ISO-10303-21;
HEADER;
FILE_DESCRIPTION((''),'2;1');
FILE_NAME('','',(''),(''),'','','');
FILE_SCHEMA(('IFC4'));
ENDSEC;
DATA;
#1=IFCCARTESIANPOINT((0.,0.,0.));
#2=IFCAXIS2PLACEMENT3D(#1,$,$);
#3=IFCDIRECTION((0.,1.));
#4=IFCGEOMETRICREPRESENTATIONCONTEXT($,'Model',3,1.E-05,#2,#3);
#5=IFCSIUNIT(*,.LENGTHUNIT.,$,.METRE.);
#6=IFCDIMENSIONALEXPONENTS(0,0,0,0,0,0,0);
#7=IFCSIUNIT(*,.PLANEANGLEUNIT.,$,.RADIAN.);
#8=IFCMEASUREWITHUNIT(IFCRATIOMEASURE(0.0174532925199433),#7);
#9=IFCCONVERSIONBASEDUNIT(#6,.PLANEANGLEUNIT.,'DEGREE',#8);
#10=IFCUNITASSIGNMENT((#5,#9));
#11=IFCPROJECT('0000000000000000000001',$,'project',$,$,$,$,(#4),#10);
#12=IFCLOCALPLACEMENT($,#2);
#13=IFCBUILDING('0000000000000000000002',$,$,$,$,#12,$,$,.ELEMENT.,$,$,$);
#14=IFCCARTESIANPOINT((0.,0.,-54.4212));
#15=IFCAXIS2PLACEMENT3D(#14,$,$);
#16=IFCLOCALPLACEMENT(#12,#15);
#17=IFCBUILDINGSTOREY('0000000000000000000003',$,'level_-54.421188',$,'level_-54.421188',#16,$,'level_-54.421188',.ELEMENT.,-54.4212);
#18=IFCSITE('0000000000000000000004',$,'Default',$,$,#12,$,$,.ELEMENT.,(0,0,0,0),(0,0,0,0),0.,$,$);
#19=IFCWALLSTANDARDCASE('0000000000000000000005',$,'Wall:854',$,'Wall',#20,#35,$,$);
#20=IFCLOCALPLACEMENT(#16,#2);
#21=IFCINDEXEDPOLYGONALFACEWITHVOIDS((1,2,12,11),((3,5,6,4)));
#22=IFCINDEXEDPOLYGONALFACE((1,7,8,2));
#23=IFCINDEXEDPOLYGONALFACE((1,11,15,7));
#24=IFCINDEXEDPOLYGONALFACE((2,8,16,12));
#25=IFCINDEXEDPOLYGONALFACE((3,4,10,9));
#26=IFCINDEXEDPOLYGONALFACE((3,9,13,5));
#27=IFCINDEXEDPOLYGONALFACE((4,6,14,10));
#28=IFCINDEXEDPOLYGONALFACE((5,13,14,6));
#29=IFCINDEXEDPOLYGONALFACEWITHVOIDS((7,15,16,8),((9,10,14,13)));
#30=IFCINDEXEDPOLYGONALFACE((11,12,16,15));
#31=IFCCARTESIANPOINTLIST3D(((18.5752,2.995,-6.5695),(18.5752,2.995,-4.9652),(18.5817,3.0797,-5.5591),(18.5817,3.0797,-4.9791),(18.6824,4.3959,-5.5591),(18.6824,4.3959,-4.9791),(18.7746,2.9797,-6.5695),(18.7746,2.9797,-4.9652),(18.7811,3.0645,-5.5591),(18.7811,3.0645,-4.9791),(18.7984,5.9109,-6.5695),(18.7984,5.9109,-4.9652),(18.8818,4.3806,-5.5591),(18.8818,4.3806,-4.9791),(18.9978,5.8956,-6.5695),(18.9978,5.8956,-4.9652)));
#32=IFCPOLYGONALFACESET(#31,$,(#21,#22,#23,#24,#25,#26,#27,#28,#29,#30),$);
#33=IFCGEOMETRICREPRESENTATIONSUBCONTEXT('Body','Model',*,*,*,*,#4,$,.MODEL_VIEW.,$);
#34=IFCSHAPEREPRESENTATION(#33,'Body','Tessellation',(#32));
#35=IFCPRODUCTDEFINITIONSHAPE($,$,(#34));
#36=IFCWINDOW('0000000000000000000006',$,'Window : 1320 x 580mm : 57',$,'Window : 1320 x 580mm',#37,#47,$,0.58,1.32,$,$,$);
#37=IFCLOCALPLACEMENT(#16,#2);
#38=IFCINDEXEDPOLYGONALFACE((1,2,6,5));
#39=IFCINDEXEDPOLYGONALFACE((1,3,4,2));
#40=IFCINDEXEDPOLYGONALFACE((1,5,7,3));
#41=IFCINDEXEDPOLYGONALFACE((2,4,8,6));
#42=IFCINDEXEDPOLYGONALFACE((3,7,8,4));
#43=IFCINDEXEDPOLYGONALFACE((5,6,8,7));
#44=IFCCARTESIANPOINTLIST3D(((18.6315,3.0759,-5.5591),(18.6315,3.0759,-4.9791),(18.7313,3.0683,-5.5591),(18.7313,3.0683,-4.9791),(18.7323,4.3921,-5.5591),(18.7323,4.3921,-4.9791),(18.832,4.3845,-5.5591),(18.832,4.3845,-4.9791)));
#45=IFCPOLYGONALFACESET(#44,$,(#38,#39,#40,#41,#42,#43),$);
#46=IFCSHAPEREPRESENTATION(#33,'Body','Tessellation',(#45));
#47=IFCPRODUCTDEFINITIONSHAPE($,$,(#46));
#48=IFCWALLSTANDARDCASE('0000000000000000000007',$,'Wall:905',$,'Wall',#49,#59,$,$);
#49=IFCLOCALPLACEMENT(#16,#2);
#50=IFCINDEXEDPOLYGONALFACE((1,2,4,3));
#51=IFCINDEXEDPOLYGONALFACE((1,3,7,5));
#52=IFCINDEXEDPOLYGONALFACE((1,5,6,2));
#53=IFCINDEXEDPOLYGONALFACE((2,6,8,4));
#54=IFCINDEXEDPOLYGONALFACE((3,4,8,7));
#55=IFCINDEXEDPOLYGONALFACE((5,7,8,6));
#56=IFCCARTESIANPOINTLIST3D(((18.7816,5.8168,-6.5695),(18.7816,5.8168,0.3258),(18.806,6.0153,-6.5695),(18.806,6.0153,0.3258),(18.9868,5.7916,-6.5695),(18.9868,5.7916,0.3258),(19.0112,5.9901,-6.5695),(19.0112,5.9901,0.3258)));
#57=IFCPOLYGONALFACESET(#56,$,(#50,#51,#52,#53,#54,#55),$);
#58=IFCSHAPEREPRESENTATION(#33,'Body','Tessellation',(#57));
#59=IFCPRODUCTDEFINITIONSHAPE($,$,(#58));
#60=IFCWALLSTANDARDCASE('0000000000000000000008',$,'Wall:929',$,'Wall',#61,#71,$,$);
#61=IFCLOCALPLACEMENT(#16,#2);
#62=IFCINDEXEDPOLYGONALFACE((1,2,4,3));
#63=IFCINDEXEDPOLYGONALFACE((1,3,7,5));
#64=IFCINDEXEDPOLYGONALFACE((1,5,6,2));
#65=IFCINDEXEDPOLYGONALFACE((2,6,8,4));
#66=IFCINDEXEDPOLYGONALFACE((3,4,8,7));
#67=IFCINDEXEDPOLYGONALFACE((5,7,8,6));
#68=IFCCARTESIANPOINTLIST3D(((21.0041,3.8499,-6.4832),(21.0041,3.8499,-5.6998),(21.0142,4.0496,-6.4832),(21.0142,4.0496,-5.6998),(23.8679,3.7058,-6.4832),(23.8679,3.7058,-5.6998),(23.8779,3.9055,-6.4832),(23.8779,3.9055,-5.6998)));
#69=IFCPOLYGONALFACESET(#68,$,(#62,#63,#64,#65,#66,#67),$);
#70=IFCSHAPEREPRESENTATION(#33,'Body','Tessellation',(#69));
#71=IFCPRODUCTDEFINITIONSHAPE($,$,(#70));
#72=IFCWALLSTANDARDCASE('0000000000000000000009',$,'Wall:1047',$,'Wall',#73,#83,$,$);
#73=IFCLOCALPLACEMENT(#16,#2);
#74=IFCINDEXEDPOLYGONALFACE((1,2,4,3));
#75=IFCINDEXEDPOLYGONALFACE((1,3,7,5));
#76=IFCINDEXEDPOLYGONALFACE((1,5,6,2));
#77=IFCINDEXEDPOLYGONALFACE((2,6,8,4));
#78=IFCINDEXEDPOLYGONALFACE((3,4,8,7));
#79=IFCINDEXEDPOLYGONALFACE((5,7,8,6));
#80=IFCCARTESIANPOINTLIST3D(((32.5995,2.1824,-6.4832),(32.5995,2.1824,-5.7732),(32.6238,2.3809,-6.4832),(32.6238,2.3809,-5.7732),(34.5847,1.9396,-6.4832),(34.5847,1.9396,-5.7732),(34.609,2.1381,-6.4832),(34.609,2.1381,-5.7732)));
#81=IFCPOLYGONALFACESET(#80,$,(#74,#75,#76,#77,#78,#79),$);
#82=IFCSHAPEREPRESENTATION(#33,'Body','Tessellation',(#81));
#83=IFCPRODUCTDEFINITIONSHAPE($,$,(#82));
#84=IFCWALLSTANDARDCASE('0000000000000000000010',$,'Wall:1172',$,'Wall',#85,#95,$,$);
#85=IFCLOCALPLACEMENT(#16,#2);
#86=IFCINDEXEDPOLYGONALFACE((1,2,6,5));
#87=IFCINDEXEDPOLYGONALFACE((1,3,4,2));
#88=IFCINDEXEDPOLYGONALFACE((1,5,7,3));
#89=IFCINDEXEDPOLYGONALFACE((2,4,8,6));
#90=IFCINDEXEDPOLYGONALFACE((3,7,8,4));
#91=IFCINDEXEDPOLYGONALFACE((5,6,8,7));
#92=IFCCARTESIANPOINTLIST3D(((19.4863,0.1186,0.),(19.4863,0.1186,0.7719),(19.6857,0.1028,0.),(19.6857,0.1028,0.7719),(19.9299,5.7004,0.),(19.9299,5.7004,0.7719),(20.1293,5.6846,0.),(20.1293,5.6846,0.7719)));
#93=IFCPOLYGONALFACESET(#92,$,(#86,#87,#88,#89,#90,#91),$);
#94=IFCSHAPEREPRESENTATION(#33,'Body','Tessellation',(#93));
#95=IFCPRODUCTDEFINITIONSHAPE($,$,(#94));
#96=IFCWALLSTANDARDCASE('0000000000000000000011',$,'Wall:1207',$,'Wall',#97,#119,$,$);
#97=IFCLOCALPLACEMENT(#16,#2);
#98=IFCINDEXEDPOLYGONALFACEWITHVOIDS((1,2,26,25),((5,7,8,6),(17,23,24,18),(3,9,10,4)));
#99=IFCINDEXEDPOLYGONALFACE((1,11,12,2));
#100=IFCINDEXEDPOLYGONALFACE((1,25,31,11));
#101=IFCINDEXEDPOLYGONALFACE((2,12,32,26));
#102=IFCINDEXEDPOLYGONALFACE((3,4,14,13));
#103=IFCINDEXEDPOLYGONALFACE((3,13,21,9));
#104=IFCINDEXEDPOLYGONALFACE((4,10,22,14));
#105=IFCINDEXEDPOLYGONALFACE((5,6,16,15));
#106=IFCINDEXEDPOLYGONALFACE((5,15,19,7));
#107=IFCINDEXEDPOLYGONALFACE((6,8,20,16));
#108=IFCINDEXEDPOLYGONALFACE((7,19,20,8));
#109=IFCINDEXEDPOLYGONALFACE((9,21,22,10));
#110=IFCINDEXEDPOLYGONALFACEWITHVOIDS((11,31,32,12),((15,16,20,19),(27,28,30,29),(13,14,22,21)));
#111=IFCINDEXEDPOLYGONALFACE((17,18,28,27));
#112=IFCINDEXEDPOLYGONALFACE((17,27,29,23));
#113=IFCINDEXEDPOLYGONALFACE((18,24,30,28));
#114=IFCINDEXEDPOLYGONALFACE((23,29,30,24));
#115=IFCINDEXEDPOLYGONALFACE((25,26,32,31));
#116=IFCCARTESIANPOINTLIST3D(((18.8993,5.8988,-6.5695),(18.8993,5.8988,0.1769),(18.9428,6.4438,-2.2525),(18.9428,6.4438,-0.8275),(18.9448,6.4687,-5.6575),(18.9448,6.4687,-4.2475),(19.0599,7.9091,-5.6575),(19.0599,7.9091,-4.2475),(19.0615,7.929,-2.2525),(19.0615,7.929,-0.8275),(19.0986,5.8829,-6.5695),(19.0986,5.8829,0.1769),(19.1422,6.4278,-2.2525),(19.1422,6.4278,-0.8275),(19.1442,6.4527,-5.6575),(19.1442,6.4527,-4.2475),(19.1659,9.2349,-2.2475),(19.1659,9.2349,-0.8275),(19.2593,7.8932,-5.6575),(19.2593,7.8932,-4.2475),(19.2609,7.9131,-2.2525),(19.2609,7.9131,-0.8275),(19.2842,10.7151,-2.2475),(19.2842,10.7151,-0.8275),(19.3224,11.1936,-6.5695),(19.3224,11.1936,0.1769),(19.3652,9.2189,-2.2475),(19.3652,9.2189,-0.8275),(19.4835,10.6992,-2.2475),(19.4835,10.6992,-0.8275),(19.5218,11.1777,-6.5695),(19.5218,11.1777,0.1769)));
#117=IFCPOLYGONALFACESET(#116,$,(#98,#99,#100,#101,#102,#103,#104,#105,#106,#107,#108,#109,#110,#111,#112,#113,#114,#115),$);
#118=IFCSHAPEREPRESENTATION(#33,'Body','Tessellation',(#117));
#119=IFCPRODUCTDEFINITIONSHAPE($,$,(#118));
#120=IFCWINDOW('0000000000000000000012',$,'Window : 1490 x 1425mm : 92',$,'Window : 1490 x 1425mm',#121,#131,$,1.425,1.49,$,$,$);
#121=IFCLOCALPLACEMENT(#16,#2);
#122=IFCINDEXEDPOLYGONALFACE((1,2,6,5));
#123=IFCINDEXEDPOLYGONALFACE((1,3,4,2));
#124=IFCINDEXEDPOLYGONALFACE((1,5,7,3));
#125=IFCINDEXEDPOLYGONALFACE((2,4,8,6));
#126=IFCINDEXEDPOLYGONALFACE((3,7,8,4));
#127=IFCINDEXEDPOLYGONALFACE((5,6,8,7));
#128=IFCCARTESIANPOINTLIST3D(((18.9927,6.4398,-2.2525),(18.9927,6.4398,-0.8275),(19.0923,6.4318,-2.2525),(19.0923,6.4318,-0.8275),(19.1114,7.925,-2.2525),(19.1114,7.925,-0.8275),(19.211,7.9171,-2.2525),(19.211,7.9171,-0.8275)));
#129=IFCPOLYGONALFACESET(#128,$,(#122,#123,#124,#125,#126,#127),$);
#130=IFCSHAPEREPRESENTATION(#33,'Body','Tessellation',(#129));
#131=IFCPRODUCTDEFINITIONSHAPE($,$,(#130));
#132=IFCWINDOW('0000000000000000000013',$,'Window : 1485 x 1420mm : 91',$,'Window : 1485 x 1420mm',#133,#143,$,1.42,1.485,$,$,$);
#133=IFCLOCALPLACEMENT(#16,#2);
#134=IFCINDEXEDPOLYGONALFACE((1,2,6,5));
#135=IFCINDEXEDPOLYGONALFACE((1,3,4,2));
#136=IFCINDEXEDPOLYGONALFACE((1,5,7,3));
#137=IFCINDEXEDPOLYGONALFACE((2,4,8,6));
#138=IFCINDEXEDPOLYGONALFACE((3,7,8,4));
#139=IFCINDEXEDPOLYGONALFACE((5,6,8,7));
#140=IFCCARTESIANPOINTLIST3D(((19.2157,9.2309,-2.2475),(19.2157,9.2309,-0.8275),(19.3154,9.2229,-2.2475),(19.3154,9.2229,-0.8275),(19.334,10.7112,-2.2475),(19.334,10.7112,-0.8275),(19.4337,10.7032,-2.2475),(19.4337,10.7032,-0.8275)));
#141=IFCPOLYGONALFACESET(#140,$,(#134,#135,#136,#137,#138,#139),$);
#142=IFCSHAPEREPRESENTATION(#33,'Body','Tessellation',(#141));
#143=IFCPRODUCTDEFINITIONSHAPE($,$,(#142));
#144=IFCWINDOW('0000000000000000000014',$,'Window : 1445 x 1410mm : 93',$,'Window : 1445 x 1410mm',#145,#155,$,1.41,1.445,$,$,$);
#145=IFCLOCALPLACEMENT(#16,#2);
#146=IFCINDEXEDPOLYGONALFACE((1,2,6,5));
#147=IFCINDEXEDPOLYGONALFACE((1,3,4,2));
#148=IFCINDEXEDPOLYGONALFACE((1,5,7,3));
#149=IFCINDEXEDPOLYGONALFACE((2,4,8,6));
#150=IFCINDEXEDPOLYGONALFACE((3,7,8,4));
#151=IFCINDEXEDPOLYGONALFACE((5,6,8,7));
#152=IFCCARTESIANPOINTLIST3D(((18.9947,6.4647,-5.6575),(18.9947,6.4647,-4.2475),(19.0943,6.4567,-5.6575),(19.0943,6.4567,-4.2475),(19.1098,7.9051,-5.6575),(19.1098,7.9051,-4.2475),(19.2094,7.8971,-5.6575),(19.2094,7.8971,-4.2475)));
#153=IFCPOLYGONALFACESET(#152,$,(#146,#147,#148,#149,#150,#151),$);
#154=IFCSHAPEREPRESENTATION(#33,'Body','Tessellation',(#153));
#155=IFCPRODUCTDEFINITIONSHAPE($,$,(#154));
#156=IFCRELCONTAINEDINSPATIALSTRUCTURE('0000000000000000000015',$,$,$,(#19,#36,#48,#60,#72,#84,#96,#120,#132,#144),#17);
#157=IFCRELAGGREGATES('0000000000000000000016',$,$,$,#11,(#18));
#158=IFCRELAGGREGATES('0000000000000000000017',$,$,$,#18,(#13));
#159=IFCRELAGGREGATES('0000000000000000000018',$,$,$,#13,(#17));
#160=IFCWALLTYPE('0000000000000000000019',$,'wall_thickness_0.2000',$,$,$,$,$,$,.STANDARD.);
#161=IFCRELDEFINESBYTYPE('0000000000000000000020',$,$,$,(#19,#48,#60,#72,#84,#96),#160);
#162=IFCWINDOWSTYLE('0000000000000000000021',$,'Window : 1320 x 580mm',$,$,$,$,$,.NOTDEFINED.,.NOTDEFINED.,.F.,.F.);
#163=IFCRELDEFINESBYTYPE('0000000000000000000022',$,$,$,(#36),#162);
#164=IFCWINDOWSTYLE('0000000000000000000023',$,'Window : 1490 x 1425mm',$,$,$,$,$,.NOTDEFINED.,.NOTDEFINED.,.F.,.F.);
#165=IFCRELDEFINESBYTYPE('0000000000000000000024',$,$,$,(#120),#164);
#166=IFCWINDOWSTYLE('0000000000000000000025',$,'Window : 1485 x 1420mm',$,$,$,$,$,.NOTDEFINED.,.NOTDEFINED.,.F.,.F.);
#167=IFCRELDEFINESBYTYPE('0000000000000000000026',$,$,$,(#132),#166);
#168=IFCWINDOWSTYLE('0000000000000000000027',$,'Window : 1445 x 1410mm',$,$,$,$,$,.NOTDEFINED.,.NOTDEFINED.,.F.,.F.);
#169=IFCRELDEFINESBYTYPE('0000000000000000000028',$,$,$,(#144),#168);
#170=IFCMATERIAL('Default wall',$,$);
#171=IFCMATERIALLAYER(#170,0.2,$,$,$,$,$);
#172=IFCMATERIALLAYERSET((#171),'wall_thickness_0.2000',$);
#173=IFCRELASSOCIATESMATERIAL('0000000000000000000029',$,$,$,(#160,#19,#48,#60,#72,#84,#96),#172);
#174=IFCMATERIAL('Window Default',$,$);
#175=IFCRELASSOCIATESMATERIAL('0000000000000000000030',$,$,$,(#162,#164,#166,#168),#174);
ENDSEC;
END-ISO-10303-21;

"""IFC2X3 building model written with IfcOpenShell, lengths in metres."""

from ifc_helpers import new_model, entity, si_unit, converted_unit, direction, frame, frame_2d, origin, origin_2d_with_axis, place, context, subcontext, project, spatial, polyline, rectangle, outline, extrude, source, transform, mapped, material, layer, layer_set, layer_usage, type_object, type_shapes, element, fill, save


model = new_model("IFC2X3")

# Units and contexts
model_context = context("Model", 3, precision=1e-05, world=origin(), true_north=direction((0.0, 1.0)))
body_context = subcontext(model_context, "Body", "Model", "MODEL_VIEW")
ifc_project = project(units=[si_unit("LENGTHUNIT", "METRE"), converted_unit("PLANEANGLEUNIT", "DEGREE", entity("IfcRatioMeasure", 0.0174532925199433), si_unit("PLANEANGLEUNIT", "RADIAN"), dimensions=[0, 0, 0, 0, 0, 0, 0])], contexts=[model_context])

# Site, building, storey
placement_1 = place(None, origin())
site = spatial("IfcSite", under=ifc_project, at=placement_1, Name="Default", CompositionType="ELEMENT", RefLatitude=(0, 0, 0, 0), RefLongitude=(0, 0, 0, 0), RefElevation=0.0)
building = spatial("IfcBuilding", under=site, at=placement_1, CompositionType="ELEMENT")
storey_placement = place(placement_1, frame((0.0, 0.0, -54.4212)))
storey = spatial("IfcBuildingStorey", under=building, at=storey_placement, Name="level_-54.421188", ObjectType="level_-54.421188", LongName="level_-54.421188", CompositionType="ELEMENT", Elevation=-54.4212)

# Shared definitions
ifc_material_1 = material(Name="Default wall")
ifc_layer = layer(ifc_material_1, 0.2)
ifc_layer_set = layer_set([ifc_layer], Name="wall_thickness_0.2000")
ifc_layer_usage = layer_usage(ifc_layer_set, "AXIS2", "POSITIVE", -0.1)
wall_type = type_object("IfcWallType", Name="wall_thickness_0.2000", PredefinedType="STANDARD", material=ifc_layer_set)
ifc_material_2 = material(Name="Window Default")

# Wall, opening, window
placement_2 = place(placement_1, frame((0.0, 0.0, -60.9907)))
wall_1_placement = place(placement_2, frame((18.8981, 5.9033, 0.0), z_axis=(0.0, 0.0, 1.0), x_axis=(-0.076307, -0.997084, 0.0)))
wall_1 = element("IfcWallStandardCase", 1, at=wall_1_placement, inside=storey, type_object=wall_type, material=ifc_layer_usage, Name="Wall:854", ObjectType="Wall", context=body_context, shape_type="SweptSolid", body=[
    extrude(outline(polyline([(2.9244, -0.1), (2.9244, 0.1), (0.0, 0.1), (0.0, -0.1), (2.9244, -0.1)])), origin(), (0.0, 0.0, 1.0), 1.6043),
])
opening_1_placement = place(wall_1_placement, frame((1.5194, -0.1, 1.0103)))
opening_1 = element("IfcOpeningElement", 2, at=opening_1_placement, cuts=wall_1, ObjectType="Opening", context=body_context, shape_type="SweptSolid", body=[
    extrude(rectangle(XDim=1.32, YDim=0.58, at=frame_2d((0.29, 0.66), x_axis=(0.0, 1.0))), frame((0.0, 0.0, 0.0), z_axis=(0.0, 1.0, 0.0), x_axis=(0.0, 0.0, 1.0)), (0.0, 0.0, 1.0), 0.2),
])
window_style_1 = type_object("IfcWindowStyle", Name="Window : 1320 x 580mm", ConstructionType="NOTDEFINED", OperationType="NOTDEFINED", ParameterTakesPrecedence=False, Sizeable=False, material=ifc_material_2)
shared_shape_1 = source(origin(), body_context, "Body", "SweptSolid", [
    extrude(rectangle(XDim=0.1, YDim=1.32, at=origin_2d_with_axis()), frame((0.66, 0.1, 0.0), z_axis=(0.0, 0.0, 1.0), x_axis=(0.0, 1.0, 0.0)), (0.0, 0.0, 1.0), 0.58),
])
type_shapes(window_style_1, [shared_shape_1])
window_1_placement = place(opening_1_placement, origin())
window_1 = element("IfcWindow", 3, at=window_1_placement, inside=storey, type_object=window_style_1, Name="Window : 1320 x 580mm : 57", ObjectType="Window : 1320 x 580mm", OverallHeight=0.58, OverallWidth=1.32, context=body_context, shape_type="MappedRepresentation", body=[
    mapped(shared_shape_1, transform((0.0, 0.0, 0.0), scale=1.0)),
])
fill(opening_1, window_1)

# Walls
placement_3 = place(placement_1, frame((0.0, 0.0, -60.9907)))
wall_2_placement = place(placement_3, frame((18.999, 5.8909, 0.0), z_axis=(0.0, 0.0, 1.0), x_axis=(-0.992531, 0.121989, 0.0)))
element("IfcWallStandardCase", 4, at=wall_2_placement, inside=storey, type_object=wall_type, material=ifc_layer_usage, Name="Wall:905", ObjectType="Wall", context=body_context, shape_type="SweptSolid", body=[
    extrude(outline(polyline([(0.2067, -0.1), (0.2067, 0.1), (0.0, 0.1), (0.0, -0.1), (0.2067, -0.1)])), origin(), (0.0, 0.0, 1.0), 6.8953),
])
placement_4 = place(placement_1, frame((0.0, 0.0, -60.9044)))
wall_3_placement = place(placement_4, frame((21.0091, 3.9497, 0.0), z_axis=(0.0, 0.0, 1.0), x_axis=(0.998736, -0.050257, 0.0)))
element("IfcWallStandardCase", 5, at=wall_3_placement, inside=storey, type_object=wall_type, material=ifc_layer_usage, Name="Wall:929", ObjectType="Wall", context=body_context, shape_type="SweptSolid", body=[
    extrude(outline(polyline([(2.8674, -0.1), (2.8674, 0.1), (0.0, 0.1), (0.0, -0.1), (2.8674, -0.1)])), origin(), (0.0, 0.0, 1.0), 0.7835),
])
placement_5 = place(placement_1, frame((0.0, 0.0, -60.9044)))
wall_4_placement = place(placement_5, frame((32.6116, 2.2817, 0.0), z_axis=(0.0, 0.0, 1.0), x_axis=(0.992601, -0.121423, 0.0)))
element("IfcWallStandardCase", 6, at=wall_4_placement, inside=storey, type_object=wall_type, material=ifc_layer_usage, Name="Wall:1047", ObjectType="Wall", context=body_context, shape_type="SweptSolid", body=[
    extrude(outline(polyline([(2.0, -0.1), (2.0, 0.1), (0.0, 0.1), (0.0, -0.1), (2.0, -0.1)])), origin(), (0.0, 0.0, 1.0), 0.7101),
])
wall_5_placement = place(storey_placement, frame((19.586, 0.1107, 0.0), z_axis=(0.0, 0.0, 1.0), x_axis=(0.079231, 0.996856, 0.0)))
element("IfcWallStandardCase", 7, at=wall_5_placement, inside=storey, type_object=wall_type, material=ifc_layer_usage, Name="Wall:1172", ObjectType="Wall", context=body_context, shape_type="SweptSolid", body=[
    extrude(outline(polyline([(5.5994, -0.1), (5.5994, 0.1), (0.0, 0.1), (0.0, -0.1), (5.5994, -0.1)])), origin(), (0.0, 0.0, 1.0), 0.7719),
])

# Wall, openings, windows
placement_6 = place(placement_1, frame((0.0, 0.0, -60.9907)))
wall_6_placement = place(placement_6, frame((19.4221, 11.1857, 0.0), z_axis=(0.0, 0.0, 1.0), x_axis=(-0.079663, -0.996822, 0.0)))
wall_6 = element("IfcWallStandardCase", 8, at=wall_6_placement, inside=storey, type_object=wall_type, material=ifc_layer_usage, Name="Wall:1207", ObjectType="Wall", context=body_context, shape_type="SweptSolid", body=[
    extrude(outline(polyline([(5.3117, -0.1), (5.3117, 0.1), (0.0, 0.1), (0.0, -0.1), (5.3117, -0.1)])), origin(), (0.0, 0.0, 1.0), 6.7464),
])
opening_2_placement = place(wall_6_placement, frame((0.48, -0.1, 4.3219)))
opening_2 = element("IfcOpeningElement", 9, at=opening_2_placement, cuts=wall_6, ObjectType="Opening", context=body_context, shape_type="SweptSolid", body=[
    extrude(rectangle(XDim=1.485, YDim=1.42, at=frame_2d((0.71, 0.7425), x_axis=(0.0, 1.0))), frame((0.0, 0.0, 0.0), z_axis=(0.0, 1.0, 0.0), x_axis=(0.0, 0.0, 1.0)), (0.0, 0.0, 1.0), 0.2),
])
opening_3_placement = place(wall_6_placement, frame((3.275, -0.1, 4.3169)))
opening_3 = element("IfcOpeningElement", 10, at=opening_3_placement, cuts=wall_6, ObjectType="Opening", context=body_context, shape_type="SweptSolid", body=[
    extrude(rectangle(XDim=1.49, YDim=1.425, at=frame_2d((0.7125, 0.745), x_axis=(0.0, 1.0))), frame((0.0, 0.0, 0.0), z_axis=(0.0, 1.0, 0.0), x_axis=(0.0, 0.0, 1.0)), (0.0, 0.0, 1.0), 0.2),
])
opening_4_placement = place(wall_6_placement, frame((3.295, -0.1, 0.9119)))
opening_4 = element("IfcOpeningElement", 11, at=opening_4_placement, cuts=wall_6, ObjectType="Opening", context=body_context, shape_type="SweptSolid", body=[
    extrude(rectangle(XDim=1.445, YDim=1.41, at=frame_2d((0.705, 0.7225), x_axis=(0.0, 1.0))), frame((0.0, 0.0, 0.0), z_axis=(0.0, 1.0, 0.0), x_axis=(0.0, 0.0, 1.0)), (0.0, 0.0, 1.0), 0.2),
])
window_style_2 = type_object("IfcWindowStyle", Name="Window : 1490 x 1425mm", ConstructionType="NOTDEFINED", OperationType="NOTDEFINED", ParameterTakesPrecedence=False, Sizeable=False, material=ifc_material_2)
shared_shape_2 = source(origin(), body_context, "Body", "SweptSolid", [
    extrude(rectangle(XDim=0.1, YDim=1.49, at=origin_2d_with_axis()), frame((0.745, 0.1, 0.0), z_axis=(0.0, 0.0, 1.0), x_axis=(0.0, 1.0, 0.0)), (0.0, 0.0, 1.0), 1.425),
])
type_shapes(window_style_2, [shared_shape_2])
window_2_placement = place(opening_3_placement, origin())
window_2 = element("IfcWindow", 12, at=window_2_placement, inside=storey, type_object=window_style_2, Name="Window : 1490 x 1425mm : 92", ObjectType="Window : 1490 x 1425mm", OverallHeight=1.425, OverallWidth=1.49, context=body_context, shape_type="MappedRepresentation", body=[
    mapped(shared_shape_2, transform((0.0, 0.0, 0.0), scale=1.0)),
])
fill(opening_3, window_2)
window_style_3 = type_object("IfcWindowStyle", Name="Window : 1485 x 1420mm", ConstructionType="NOTDEFINED", OperationType="NOTDEFINED", ParameterTakesPrecedence=False, Sizeable=False, material=ifc_material_2)
shared_shape_3 = source(origin(), body_context, "Body", "SweptSolid", [
    extrude(rectangle(XDim=0.1, YDim=1.485, at=origin_2d_with_axis()), frame((0.7425, 0.1, 0.0), z_axis=(0.0, 0.0, 1.0), x_axis=(0.0, 1.0, 0.0)), (0.0, 0.0, 1.0), 1.42),
])
type_shapes(window_style_3, [shared_shape_3])
window_3_placement = place(opening_2_placement, origin())
window_3 = element("IfcWindow", 13, at=window_3_placement, inside=storey, type_object=window_style_3, Name="Window : 1485 x 1420mm : 91", ObjectType="Window : 1485 x 1420mm", OverallHeight=1.42, OverallWidth=1.485, context=body_context, shape_type="MappedRepresentation", body=[
    mapped(shared_shape_3, transform((0.0, 0.0, 0.0), scale=1.0)),
])
fill(opening_2, window_3)
window_style_4 = type_object("IfcWindowStyle", Name="Window : 1445 x 1410mm", ConstructionType="NOTDEFINED", OperationType="NOTDEFINED", ParameterTakesPrecedence=False, Sizeable=False, material=ifc_material_2)
shared_shape_4 = source(origin(), body_context, "Body", "SweptSolid", [
    extrude(rectangle(XDim=0.1, YDim=1.445, at=origin_2d_with_axis()), frame((0.7225, 0.1, 0.0), z_axis=(0.0, 0.0, 1.0), x_axis=(0.0, 1.0, 0.0)), (0.0, 0.0, 1.0), 1.41),
])
type_shapes(window_style_4, [shared_shape_4])
window_4_placement = place(opening_4_placement, origin())
window_4 = element("IfcWindow", 14, at=window_4_placement, inside=storey, type_object=window_style_4, Name="Window : 1445 x 1410mm : 93", ObjectType="Window : 1445 x 1410mm", OverallHeight=1.41, OverallWidth=1.445, context=body_context, shape_type="MappedRepresentation", body=[
    mapped(shared_shape_4, transform((0.0, 0.0, 0.0), scale=1.0)),
])
fill(opening_4, window_4)

save(model, "model.ifc")
